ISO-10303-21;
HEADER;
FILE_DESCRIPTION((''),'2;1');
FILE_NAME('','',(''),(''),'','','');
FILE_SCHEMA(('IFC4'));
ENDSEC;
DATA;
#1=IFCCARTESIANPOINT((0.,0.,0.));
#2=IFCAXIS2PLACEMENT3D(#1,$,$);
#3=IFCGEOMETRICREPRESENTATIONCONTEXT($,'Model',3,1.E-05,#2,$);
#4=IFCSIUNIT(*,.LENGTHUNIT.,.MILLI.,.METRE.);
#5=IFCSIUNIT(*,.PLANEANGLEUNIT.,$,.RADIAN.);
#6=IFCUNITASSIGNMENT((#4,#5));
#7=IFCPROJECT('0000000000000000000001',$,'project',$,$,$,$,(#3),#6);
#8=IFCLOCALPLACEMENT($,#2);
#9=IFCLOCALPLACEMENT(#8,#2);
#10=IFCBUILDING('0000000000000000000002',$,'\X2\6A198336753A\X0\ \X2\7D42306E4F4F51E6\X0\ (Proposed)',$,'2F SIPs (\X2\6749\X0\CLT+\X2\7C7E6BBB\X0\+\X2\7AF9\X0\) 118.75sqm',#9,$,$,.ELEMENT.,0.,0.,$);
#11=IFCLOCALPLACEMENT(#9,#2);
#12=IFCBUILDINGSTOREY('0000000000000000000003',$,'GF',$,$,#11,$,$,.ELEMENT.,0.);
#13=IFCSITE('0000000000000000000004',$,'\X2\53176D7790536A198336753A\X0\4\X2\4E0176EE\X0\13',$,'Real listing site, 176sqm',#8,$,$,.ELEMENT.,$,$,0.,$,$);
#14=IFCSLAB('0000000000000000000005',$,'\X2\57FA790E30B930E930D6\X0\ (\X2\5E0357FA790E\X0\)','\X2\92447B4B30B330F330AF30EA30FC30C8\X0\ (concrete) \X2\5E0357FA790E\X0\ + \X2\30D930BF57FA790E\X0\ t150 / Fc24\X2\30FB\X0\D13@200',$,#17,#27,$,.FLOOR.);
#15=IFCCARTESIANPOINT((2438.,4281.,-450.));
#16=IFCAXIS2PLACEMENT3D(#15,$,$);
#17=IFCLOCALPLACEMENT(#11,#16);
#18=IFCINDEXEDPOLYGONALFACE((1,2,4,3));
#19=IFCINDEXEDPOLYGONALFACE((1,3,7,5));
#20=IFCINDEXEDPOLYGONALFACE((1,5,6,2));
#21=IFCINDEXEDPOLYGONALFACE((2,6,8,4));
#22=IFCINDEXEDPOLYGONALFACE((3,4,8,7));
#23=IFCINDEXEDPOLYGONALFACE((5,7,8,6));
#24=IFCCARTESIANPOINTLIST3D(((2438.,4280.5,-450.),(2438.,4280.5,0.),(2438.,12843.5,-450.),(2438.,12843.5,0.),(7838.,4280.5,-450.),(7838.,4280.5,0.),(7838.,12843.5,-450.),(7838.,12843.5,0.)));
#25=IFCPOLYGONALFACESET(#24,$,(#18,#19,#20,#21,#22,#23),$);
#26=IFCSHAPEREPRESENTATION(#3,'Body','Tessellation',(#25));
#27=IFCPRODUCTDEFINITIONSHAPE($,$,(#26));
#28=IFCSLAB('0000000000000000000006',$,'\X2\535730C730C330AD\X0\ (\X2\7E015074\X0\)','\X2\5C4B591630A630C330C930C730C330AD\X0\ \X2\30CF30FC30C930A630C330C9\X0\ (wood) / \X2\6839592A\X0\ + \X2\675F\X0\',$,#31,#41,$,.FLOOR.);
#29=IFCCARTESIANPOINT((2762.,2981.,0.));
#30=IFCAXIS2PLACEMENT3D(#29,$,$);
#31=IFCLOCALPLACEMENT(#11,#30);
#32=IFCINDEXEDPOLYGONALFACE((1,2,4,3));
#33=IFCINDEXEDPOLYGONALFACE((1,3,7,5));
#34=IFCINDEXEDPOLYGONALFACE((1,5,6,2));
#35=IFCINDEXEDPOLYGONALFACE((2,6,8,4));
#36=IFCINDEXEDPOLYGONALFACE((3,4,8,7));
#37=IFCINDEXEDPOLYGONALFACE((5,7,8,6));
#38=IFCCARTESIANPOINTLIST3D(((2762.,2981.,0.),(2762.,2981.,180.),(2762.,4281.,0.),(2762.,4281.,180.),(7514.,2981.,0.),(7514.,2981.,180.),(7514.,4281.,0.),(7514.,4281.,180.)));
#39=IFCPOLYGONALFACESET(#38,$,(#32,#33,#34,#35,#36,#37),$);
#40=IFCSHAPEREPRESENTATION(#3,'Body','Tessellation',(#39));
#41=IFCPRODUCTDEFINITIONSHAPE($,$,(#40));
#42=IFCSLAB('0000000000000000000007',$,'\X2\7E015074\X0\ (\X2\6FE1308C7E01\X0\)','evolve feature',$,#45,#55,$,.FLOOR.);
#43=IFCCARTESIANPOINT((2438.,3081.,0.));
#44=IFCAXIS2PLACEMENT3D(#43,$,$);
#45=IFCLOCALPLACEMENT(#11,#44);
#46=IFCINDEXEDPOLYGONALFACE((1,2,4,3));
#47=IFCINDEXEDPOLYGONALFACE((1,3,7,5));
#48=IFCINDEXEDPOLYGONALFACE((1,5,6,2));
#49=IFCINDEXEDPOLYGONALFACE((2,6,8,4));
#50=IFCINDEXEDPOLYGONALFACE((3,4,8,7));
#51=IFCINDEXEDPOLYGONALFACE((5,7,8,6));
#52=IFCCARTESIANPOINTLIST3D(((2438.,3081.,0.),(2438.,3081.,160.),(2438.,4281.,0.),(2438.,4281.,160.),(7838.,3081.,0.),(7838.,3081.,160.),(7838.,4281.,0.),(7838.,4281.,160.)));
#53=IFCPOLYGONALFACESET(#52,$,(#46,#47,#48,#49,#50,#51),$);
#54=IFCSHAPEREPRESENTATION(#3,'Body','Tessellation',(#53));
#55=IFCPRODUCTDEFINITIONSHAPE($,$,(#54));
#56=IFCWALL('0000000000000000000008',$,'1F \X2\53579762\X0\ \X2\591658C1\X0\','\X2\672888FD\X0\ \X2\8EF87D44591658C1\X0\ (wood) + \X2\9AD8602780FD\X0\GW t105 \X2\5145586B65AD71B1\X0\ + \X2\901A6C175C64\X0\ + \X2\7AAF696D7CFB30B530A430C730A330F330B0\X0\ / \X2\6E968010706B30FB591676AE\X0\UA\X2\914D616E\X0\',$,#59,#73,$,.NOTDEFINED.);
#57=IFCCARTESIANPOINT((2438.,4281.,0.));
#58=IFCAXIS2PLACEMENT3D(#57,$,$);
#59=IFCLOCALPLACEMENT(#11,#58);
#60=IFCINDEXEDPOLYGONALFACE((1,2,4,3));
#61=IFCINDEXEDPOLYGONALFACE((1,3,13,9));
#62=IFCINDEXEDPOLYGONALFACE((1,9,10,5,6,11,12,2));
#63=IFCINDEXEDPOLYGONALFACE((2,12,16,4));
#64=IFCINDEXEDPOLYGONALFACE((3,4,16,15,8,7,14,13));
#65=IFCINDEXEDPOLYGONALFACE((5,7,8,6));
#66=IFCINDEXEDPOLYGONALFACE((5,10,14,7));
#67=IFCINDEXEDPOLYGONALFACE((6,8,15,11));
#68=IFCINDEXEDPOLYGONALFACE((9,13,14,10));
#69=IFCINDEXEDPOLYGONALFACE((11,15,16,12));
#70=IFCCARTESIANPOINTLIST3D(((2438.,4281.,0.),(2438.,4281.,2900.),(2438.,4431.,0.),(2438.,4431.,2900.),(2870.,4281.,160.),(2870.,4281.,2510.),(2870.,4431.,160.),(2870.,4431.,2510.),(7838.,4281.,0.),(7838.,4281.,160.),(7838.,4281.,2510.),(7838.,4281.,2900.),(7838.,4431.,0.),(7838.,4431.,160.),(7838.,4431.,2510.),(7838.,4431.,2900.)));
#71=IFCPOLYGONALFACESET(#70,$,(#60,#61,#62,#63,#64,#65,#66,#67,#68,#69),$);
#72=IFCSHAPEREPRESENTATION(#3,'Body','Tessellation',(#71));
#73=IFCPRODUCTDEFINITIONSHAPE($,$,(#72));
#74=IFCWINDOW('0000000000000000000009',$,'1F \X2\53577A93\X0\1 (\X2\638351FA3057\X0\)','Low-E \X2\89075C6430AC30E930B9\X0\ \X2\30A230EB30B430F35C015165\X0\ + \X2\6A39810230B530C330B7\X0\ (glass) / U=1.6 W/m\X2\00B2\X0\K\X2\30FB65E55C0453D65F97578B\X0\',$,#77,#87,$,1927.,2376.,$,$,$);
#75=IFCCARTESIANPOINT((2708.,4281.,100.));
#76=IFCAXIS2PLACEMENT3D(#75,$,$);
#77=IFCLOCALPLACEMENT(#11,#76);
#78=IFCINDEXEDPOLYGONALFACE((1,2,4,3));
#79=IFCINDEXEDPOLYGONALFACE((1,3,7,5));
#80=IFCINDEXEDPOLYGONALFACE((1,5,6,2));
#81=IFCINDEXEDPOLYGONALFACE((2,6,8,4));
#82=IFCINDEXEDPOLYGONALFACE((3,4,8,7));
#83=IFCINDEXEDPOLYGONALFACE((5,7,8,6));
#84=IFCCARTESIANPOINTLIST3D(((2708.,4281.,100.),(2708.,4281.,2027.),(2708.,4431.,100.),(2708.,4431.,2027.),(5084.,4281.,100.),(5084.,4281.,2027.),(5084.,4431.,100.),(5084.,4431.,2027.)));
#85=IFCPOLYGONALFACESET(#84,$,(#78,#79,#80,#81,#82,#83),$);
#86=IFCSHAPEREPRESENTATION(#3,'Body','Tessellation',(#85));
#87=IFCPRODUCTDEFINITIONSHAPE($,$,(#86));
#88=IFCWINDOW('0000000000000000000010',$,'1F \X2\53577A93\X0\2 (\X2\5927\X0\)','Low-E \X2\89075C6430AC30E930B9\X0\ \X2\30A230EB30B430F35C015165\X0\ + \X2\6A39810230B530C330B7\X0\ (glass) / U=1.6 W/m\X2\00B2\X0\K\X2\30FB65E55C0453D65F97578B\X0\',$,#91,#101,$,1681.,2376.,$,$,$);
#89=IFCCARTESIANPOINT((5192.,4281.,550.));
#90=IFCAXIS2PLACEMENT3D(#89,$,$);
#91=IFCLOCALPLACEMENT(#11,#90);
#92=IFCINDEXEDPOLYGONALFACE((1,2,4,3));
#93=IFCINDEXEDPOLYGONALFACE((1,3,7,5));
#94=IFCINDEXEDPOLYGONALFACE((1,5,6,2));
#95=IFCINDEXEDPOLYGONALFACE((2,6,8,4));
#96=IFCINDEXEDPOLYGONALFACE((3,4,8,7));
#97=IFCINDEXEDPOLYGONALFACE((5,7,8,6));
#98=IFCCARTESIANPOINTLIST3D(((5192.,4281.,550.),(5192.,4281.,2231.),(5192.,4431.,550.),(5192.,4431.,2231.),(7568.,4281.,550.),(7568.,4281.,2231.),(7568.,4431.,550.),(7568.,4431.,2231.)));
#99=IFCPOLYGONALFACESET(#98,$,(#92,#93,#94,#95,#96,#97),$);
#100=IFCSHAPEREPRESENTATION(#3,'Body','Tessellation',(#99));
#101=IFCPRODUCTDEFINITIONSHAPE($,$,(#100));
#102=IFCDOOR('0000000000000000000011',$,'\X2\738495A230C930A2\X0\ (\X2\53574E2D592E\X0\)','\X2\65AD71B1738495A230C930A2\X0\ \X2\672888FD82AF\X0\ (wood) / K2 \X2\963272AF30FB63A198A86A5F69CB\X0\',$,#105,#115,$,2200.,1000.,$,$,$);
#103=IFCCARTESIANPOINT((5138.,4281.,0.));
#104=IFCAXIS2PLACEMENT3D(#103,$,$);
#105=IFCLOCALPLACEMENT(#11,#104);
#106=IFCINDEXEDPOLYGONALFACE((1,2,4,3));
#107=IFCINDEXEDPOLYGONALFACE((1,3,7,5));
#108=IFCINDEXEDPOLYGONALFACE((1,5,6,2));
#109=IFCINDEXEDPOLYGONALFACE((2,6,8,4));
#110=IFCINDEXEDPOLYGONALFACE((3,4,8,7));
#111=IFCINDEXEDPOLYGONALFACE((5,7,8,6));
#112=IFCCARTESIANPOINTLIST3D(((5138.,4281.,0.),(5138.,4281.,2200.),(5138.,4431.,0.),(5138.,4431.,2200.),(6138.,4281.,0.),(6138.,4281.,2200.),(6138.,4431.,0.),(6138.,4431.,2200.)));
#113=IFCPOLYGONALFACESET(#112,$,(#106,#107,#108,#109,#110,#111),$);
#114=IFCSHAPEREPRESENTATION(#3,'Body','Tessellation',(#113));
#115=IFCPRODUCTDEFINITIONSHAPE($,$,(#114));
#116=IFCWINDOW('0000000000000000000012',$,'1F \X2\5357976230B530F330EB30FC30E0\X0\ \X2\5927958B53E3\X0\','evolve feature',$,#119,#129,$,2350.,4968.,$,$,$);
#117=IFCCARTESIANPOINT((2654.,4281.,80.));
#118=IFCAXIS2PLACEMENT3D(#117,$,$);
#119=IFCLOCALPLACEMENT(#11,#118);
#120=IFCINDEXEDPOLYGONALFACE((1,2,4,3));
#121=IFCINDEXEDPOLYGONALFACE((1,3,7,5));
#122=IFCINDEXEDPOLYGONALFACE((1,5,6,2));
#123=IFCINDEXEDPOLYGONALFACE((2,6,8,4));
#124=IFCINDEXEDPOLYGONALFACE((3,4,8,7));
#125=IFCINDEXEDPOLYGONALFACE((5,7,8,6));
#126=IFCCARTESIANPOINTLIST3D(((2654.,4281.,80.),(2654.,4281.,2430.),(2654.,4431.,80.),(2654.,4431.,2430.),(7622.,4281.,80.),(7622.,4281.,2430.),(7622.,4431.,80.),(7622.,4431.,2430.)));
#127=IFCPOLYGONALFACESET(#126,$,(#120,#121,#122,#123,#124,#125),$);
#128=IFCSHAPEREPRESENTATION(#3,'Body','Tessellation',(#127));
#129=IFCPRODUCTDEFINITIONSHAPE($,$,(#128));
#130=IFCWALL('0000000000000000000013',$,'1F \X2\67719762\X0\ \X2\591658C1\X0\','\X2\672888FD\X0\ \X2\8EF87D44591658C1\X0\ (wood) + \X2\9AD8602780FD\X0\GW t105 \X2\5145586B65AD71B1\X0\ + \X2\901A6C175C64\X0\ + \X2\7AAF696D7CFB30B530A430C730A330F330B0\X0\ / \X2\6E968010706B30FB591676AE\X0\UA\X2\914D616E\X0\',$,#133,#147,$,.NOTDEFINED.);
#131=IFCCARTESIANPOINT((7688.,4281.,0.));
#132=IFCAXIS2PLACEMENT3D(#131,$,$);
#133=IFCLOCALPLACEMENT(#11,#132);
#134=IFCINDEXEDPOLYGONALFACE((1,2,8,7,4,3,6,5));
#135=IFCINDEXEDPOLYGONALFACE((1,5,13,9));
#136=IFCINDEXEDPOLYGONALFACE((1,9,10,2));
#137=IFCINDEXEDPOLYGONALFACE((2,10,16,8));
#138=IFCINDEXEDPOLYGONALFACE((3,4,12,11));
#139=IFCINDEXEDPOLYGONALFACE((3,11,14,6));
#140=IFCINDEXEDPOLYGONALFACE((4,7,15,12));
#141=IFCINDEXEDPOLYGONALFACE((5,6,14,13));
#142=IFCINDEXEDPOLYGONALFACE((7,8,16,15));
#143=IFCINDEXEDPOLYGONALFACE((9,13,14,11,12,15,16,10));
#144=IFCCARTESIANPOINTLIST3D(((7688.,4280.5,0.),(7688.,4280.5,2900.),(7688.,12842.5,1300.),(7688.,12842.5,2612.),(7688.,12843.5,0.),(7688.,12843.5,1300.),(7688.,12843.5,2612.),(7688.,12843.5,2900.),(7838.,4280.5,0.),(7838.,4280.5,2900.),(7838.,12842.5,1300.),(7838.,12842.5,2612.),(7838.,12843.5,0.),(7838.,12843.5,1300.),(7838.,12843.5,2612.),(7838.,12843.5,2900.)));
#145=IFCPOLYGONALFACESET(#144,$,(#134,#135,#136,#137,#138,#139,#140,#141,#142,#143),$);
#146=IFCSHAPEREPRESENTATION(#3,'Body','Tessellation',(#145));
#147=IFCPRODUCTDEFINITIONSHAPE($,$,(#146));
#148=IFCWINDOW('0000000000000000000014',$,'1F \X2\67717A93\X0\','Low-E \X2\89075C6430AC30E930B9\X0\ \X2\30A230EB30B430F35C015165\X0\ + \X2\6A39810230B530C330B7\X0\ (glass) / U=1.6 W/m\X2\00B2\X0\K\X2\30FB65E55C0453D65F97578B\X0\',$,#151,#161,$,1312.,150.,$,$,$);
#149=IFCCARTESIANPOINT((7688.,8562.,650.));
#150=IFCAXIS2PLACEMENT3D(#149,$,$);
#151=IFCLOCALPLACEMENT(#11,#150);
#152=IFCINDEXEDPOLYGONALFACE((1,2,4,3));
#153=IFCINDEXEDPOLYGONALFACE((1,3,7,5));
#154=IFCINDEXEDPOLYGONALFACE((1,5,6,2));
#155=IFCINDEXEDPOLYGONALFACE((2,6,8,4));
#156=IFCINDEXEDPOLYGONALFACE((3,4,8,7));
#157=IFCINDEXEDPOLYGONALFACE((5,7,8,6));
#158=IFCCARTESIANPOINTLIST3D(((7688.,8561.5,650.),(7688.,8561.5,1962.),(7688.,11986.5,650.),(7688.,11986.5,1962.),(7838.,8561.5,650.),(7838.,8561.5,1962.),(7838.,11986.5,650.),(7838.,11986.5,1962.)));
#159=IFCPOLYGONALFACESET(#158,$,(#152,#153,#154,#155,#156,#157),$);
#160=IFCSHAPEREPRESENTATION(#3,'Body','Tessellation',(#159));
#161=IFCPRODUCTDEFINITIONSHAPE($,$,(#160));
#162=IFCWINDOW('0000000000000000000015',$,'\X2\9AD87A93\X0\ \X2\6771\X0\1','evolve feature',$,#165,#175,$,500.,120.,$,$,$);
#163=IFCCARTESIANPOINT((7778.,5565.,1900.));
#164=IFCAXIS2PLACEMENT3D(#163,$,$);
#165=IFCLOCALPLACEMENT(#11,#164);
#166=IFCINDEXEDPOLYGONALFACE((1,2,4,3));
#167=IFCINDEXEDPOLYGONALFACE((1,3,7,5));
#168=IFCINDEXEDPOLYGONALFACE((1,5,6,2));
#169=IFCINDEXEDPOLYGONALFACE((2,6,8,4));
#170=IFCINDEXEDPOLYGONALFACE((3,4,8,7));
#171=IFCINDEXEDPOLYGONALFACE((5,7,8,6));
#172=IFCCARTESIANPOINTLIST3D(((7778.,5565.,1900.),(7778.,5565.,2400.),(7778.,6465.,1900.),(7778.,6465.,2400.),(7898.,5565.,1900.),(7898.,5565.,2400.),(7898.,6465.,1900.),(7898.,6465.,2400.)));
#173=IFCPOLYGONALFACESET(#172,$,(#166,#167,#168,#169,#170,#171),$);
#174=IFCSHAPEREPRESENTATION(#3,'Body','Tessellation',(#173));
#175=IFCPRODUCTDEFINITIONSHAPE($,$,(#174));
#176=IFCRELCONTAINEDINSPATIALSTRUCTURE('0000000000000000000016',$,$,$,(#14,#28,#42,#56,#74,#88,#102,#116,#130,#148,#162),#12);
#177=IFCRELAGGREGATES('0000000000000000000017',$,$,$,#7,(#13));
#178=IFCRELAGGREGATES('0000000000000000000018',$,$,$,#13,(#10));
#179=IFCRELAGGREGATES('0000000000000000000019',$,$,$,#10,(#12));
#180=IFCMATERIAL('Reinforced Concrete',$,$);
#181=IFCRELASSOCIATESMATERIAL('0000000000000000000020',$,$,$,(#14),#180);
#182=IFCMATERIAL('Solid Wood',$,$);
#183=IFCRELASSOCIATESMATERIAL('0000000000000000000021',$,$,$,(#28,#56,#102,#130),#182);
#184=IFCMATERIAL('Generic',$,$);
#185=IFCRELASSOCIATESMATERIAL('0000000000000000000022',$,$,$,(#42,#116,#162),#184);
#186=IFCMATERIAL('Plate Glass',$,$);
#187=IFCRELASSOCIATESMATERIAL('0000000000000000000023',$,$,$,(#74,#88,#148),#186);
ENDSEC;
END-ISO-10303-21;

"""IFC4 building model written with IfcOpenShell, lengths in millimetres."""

from ifc_helpers import new_model, si_unit, frame, frame_2d, origin, place, context, project, spatial, rectangle, extrude, material, element, fill, save


model = new_model("IFC4")

# Units and contexts
model_context = context("Model", 3, precision=1e-05, world=origin())
ifc_project = project(units=[si_unit("LENGTHUNIT", "METRE", prefix="MILLI"), si_unit("PLANEANGLEUNIT", "RADIAN")], contexts=[model_context])

# Site, building, storey
site_placement = place(None, origin())
site = spatial("IfcSite", under=ifc_project, at=site_placement, Name="北海道標茶町4丁目13", ObjectType="Real listing site, 176sqm", CompositionType="ELEMENT", RefElevation=0.0)
building_placement = place(site_placement, origin())
building = spatial("IfcBuilding", under=site, at=building_placement, Name="標茶町 終の住処 (Proposed)", ObjectType="2F SIPs (杉CLT+籾殻+竹) 118.75sqm", CompositionType="ELEMENT", ElevationOfRefHeight=0.0, ElevationOfTerrain=0.0)
storey_placement = place(building_placement, origin())
storey = spatial("IfcBuildingStorey", under=building, at=storey_placement, Name="GF", CompositionType="ELEMENT", Elevation=0.0)

# Slabs
ifc_material_1 = material(Name="Reinforced Concrete")
slab_1_placement = place(storey_placement, frame((2438.0, 4281.0, -450.0)))
element("IfcSlab", 1, at=slab_1_placement, inside=storey, material=ifc_material_1, Name="基礎スラブ (布基礎)", Description="鉄筋コンクリート (concrete) 布基礎 + ベタ基礎 t150 / Fc24・D13@200", PredefinedType="FLOOR", context=model_context, shape_type="SweptSolid", body=[
    extrude(rectangle(XDim=5400.0, YDim=8563.0, at=frame_2d((2700.0, 4281.0))), frame((2438.0, 4281.0, -450.0)), (0.0, 0.0, 1.0), 450.0),
])
ifc_material_2 = material(Name="Solid Wood")
slab_2_placement = place(storey_placement, frame((2762.0, 2981.0, 0.0)))
element("IfcSlab", 2, at=slab_2_placement, inside=storey, material=ifc_material_2, Name="南デッキ (縁側)", Description="屋外ウッドデッキ ハードウッド (wood) / 根太 + 束", PredefinedType="FLOOR", context=model_context, shape_type="SweptSolid", body=[
    extrude(rectangle(XDim=4752.0, YDim=1300.0, at=frame_2d((2376.0, 650.0))), frame((2762.0, 2981.0, 0.0)), (0.0, 0.0, 1.0), 180.0),
])
ifc_material_3 = material(Name="Generic")
slab_3_placement = place(storey_placement, frame((2438.0, 3081.0, 0.0)))
element("IfcSlab", 3, at=slab_3_placement, inside=storey, material=ifc_material_3, Name="縁側 (濡れ縁)", Description="evolve feature", PredefinedType="FLOOR", context=model_context, shape_type="SweptSolid", body=[
    extrude(rectangle(XDim=5400.0, YDim=1200.0, at=frame_2d((2700.0, 600.0))), frame((2438.0, 3081.0, 0.0)), (0.0, 0.0, 1.0), 160.0),
])

# Wall, openings, windows, door
wall_1_placement = place(storey_placement, frame((2438.0, 4281.0, 0.0)))
wall_1 = element("IfcWall", 4, at=wall_1_placement, inside=storey, material=ifc_material_2, Name="1F 南面 外壁", Description="木製 軸組外壁 (wood) + 高性能GW t105 充填断熱 + 通気層 + 窯業系サイディング / 準耐火・外皮UA配慮", PredefinedType="NOTDEFINED", context=model_context, shape_type="SweptSolid", body=[
    extrude(rectangle(XDim=5400.0, YDim=150.0, at=frame_2d((2700.0, 75.0))), frame((2438.0, 4281.0, 0.0)), (0.0, 0.0, 1.0), 2900.0),
])
opening_1_placement = place(storey_placement, frame((2708.0, 4281.0, 100.0)))
opening_1 = element("IfcOpeningElement", 5, at=opening_1_placement, cuts=wall_1, PredefinedType="NOTDEFINED", context=model_context, shape_type="SweptSolid", body=[
    extrude(rectangle(XDim=2376.0, YDim=150.0, at=frame_2d((1188.0, 75.0))), frame((2708.0, 4281.0, 100.0)), (0.0, 0.0, 1.0), 1927.0),
])
opening_2_placement = place(storey_placement, frame((5192.0, 4281.0, 550.0)))
opening_2 = element("IfcOpeningElement", 6, at=opening_2_placement, cuts=wall_1, PredefinedType="NOTDEFINED", context=model_context, shape_type="SweptSolid", body=[
    extrude(rectangle(XDim=2376.0, YDim=150.0, at=frame_2d((1188.0, 75.0))), frame((5192.0, 4281.0, 550.0)), (0.0, 0.0, 1.0), 1681.0),
])
opening_3_placement = place(storey_placement, frame((5138.0, 4281.0, 0.0)))
opening_3 = element("IfcOpeningElement", 7, at=opening_3_placement, cuts=wall_1, PredefinedType="NOTDEFINED", context=model_context, shape_type="SweptSolid", body=[
    extrude(rectangle(XDim=1000.0, YDim=150.0, at=frame_2d((500.0, 75.0))), frame((5138.0, 4281.0, 0.0)), (0.0, 0.0, 1.0), 2200.0),
])
opening_4_placement = place(storey_placement, frame((2654.0, 4281.0, 80.0)))
opening_4 = element("IfcOpeningElement", 8, at=opening_4_placement, cuts=wall_1, PredefinedType="NOTDEFINED", context=model_context, shape_type="SweptSolid", body=[
    extrude(rectangle(XDim=4968.0, YDim=150.0, at=frame_2d((2484.0, 75.0))), frame((2654.0, 4281.0, 80.0)), (0.0, 0.0, 1.0), 2350.0),
])
ifc_material_4 = material(Name="Plate Glass")
window_1_placement = place(storey_placement, frame((2708.0, 4281.0, 100.0)))
window_1 = element("IfcWindow", 9, at=window_1_placement, inside=storey, material=ifc_material_4, Name="1F 南窓1 (掃出し)", Description="Low-E 複層ガラス アルゴン封入 + 樹脂サッシ (glass) / U=1.6 W/m²K・日射取得型", OverallHeight=1927.0, OverallWidth=2376.0, context=model_context, shape_type="SweptSolid", body=[
    extrude(rectangle(XDim=2376.0, YDim=150.0, at=frame_2d((1188.0, 75.0))), frame((2708.0, 4281.0, 100.0)), (0.0, 0.0, 1.0), 1927.0),
])
fill(opening_1, window_1)
window_2_placement = place(storey_placement, frame((5192.0, 4281.0, 550.0)))
window_2 = element("IfcWindow", 10, at=window_2_placement, inside=storey, material=ifc_material_4, Name="1F 南窓2 (大)", Description="Low-E 複層ガラス アルゴン封入 + 樹脂サッシ (glass) / U=1.6 W/m²K・日射取得型", OverallHeight=1681.0, OverallWidth=2376.0, context=model_context, shape_type="SweptSolid", body=[
    extrude(rectangle(XDim=2376.0, YDim=150.0, at=frame_2d((1188.0, 75.0))), frame((5192.0, 4281.0, 550.0)), (0.0, 0.0, 1.0), 1681.0),
])
fill(opening_2, window_2)
door_placement = place(storey_placement, frame((5138.0, 4281.0, 0.0)))
door = element("IfcDoor", 11, at=door_placement, inside=storey, material=ifc_material_2, Name="玄関ドア (南中央)", Description="断熱玄関ドア 木製芯 (wood) / K2 防犯・採風機構", OverallHeight=2200.0, OverallWidth=1000.0, context=model_context, shape_type="SweptSolid", body=[
    extrude(rectangle(XDim=1000.0, YDim=150.0, at=frame_2d((500.0, 75.0))), frame((5138.0, 4281.0, 0.0)), (0.0, 0.0, 1.0), 2200.0),
])
fill(opening_3, door)
window_3_placement = place(storey_placement, frame((2654.0, 4281.0, 80.0)))
window_3 = element("IfcWindow", 12, at=window_3_placement, inside=storey, material=ifc_material_3, Name="1F 南面サンルーム 大開口", Description="evolve feature", OverallHeight=2350.0, OverallWidth=4968.0, context=model_context, shape_type="SweptSolid", body=[
    extrude(rectangle(XDim=4968.0, YDim=150.0, at=frame_2d((2484.0, 75.0))), frame((2654.0, 4281.0, 80.0)), (0.0, 0.0, 1.0), 2350.0),
])
fill(opening_4, window_3)

# Wall, openings, windows
wall_2_placement = place(storey_placement, frame((7688.0, 4281.0, 0.0)))
wall_2 = element("IfcWall", 13, at=wall_2_placement, inside=storey, material=ifc_material_2, Name="1F 東面 外壁", Description="木製 軸組外壁 (wood) + 高性能GW t105 充填断熱 + 通気層 + 窯業系サイディング / 準耐火・外皮UA配慮", PredefinedType="NOTDEFINED", context=model_context, shape_type="SweptSolid", body=[
    extrude(rectangle(XDim=150.0, YDim=8563.0, at=frame_2d((75.0, 4281.0))), frame((7688.0, 4281.0, 0.0)), (0.0, 0.0, 1.0), 2900.0),
])
opening_5_placement = place(storey_placement, frame((7688.0, 8562.0, 650.0)))
opening_5 = element("IfcOpeningElement", 14, at=opening_5_placement, cuts=wall_2, PredefinedType="NOTDEFINED", context=model_context, shape_type="SweptSolid", body=[
    extrude(rectangle(XDim=150.0, YDim=3425.0, at=frame_2d((75.0, 1712.0))), frame((7688.0, 8562.0, 650.0)), (0.0, 0.0, 1.0), 1312.0),
])
opening_6_placement = place(storey_placement, frame((7778.0, 5565.0, 1900.0)))
opening_6 = element("IfcOpeningElement", 15, at=opening_6_placement, cuts=wall_2, PredefinedType="NOTDEFINED", context=model_context, shape_type="SweptSolid", body=[
    extrude(rectangle(XDim=120.0, YDim=900.0, at=frame_2d((60.0, 450.0))), frame((7778.0, 5565.0, 1900.0)), (0.0, 0.0, 1.0), 500.0),
])
window_4_placement = place(storey_placement, frame((7688.0, 8562.0, 650.0)))
window_4 = element("IfcWindow", 16, at=window_4_placement, inside=storey, material=ifc_material_4, Name="1F 東窓", Description="Low-E 複層ガラス アルゴン封入 + 樹脂サッシ (glass) / U=1.6 W/m²K・日射取得型", OverallHeight=1312.0, OverallWidth=150.0, context=model_context, shape_type="SweptSolid", body=[
    extrude(rectangle(XDim=150.0, YDim=3425.0, at=frame_2d((75.0, 1712.0))), frame((7688.0, 8562.0, 650.0)), (0.0, 0.0, 1.0), 1312.0),
])
fill(opening_5, window_4)
window_5_placement = place(storey_placement, frame((7778.0, 5565.0, 1900.0)))
window_5 = element("IfcWindow", 17, at=window_5_placement, inside=storey, material=ifc_material_3, Name="高窓 東1", Description="evolve feature", OverallHeight=500.0, OverallWidth=120.0, context=model_context, shape_type="SweptSolid", body=[
    extrude(rectangle(XDim=120.0, YDim=900.0, at=frame_2d((60.0, 450.0))), frame((7778.0, 5565.0, 1900.0)), (0.0, 0.0, 1.0), 500.0),
])
fill(opening_6, window_5)

save(model, "model.ifc")
